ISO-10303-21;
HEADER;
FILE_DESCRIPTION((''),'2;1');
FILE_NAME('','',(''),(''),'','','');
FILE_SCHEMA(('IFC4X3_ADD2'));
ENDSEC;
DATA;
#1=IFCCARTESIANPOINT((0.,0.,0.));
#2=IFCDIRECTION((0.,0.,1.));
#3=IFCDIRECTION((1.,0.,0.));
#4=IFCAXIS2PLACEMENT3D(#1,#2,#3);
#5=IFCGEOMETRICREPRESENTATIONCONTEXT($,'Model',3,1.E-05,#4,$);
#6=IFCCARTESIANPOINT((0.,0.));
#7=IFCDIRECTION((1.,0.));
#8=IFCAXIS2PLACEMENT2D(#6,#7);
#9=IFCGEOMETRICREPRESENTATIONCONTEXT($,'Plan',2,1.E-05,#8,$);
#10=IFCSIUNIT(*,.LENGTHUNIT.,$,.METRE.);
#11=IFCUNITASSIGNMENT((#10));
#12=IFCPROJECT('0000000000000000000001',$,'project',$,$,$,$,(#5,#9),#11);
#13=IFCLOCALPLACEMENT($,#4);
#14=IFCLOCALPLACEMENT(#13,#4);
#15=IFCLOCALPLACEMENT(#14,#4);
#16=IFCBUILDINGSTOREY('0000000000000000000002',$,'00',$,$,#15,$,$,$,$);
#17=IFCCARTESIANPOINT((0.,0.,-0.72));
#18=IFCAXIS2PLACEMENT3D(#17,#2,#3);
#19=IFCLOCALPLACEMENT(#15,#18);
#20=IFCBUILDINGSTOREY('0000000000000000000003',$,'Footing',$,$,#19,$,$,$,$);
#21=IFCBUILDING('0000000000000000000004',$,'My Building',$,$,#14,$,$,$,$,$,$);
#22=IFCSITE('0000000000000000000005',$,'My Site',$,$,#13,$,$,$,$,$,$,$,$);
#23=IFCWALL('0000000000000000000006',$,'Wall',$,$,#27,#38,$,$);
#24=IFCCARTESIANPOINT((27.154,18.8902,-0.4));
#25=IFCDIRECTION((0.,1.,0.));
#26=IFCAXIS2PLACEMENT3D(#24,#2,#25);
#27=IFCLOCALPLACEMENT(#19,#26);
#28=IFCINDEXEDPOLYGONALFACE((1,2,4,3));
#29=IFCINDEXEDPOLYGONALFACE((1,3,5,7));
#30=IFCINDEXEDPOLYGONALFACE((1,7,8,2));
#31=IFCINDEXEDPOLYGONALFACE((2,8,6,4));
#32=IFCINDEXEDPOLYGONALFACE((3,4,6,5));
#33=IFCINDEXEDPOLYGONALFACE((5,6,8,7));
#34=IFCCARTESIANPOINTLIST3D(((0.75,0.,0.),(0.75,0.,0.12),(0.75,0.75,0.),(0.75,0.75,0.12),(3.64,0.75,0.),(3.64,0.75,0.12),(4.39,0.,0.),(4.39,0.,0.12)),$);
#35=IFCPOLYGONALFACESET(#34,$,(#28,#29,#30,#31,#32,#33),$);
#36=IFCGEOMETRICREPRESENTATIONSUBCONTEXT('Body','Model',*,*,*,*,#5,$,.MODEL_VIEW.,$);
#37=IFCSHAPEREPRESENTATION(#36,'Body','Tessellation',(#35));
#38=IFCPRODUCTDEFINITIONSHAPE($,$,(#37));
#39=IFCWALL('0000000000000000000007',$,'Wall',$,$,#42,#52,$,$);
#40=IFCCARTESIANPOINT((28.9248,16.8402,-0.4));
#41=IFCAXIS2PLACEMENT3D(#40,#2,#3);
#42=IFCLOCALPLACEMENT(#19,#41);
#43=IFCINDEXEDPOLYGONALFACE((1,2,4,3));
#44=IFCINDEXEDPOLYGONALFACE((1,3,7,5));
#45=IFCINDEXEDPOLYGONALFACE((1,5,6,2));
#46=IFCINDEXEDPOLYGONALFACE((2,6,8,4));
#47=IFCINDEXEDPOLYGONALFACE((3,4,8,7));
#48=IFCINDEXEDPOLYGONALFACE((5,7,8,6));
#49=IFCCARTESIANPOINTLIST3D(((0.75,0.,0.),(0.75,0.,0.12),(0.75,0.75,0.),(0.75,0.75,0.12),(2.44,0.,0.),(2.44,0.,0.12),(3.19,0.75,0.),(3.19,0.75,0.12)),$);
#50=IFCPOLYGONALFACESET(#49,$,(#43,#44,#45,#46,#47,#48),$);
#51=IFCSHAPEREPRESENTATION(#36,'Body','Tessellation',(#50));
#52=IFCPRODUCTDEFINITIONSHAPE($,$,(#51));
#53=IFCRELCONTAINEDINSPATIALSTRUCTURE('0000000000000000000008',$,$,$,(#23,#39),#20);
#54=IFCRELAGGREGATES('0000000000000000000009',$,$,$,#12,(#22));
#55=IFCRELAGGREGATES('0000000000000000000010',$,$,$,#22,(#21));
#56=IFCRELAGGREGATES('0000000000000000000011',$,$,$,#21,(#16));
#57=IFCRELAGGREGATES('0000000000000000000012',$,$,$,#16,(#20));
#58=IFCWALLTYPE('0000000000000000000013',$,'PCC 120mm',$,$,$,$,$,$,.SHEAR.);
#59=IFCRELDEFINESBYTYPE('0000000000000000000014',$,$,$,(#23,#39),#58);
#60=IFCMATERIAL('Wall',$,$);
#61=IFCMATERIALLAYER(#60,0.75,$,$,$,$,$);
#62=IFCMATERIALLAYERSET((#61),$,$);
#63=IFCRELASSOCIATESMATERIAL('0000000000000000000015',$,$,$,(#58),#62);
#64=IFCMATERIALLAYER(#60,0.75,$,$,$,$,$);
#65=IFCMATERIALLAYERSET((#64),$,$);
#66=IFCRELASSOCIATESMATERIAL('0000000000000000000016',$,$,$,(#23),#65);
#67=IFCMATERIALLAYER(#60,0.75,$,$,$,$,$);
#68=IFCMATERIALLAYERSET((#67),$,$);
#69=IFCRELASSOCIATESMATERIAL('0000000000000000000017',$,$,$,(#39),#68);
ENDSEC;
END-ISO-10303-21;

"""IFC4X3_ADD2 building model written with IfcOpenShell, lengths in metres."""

from ifc_helpers import new_model, si_unit, frame, origin_with_axes, origin_2d_with_axis, place, context, subcontext, project, spatial, line, indexed_curve, outline, extrude, material, layer, layer_set, layer_usage, type_object, element, save


model = new_model("IFC4X3_ADD2")

# Units and contexts
model_context = context("Model", 3, precision=1e-05, world=origin_with_axes())
plan_context = context("Plan", 2, precision=1e-05, world=origin_2d_with_axis())
body_context = subcontext(model_context, "Body", "Model", "MODEL_VIEW")
ifc_project = project(units=[si_unit("LENGTHUNIT", "METRE")], contexts=[model_context, plan_context])

# Site, building, storeys
site_placement = place(None, origin_with_axes())
site = spatial("IfcSite", under=ifc_project, at=site_placement, Name="My Site")
building_placement = place(site_placement, origin_with_axes())
building = spatial("IfcBuilding", under=site, at=building_placement, Name="My Building")
storey_1_placement = place(building_placement, origin_with_axes())
storey_1 = spatial("IfcBuildingStorey", under=building, at=storey_1_placement, Name="00")
storey_2_placement = place(storey_1_placement, frame((0.0, 0.0, -0.72), z_axis=(0.0, 0.0, 1.0), x_axis=(1.0, 0.0, 0.0)))
storey_2 = spatial("IfcBuildingStorey", under=storey_1, at=storey_2_placement, Name="Footing")

# Shared definitions
ifc_material_1 = material(Name="Wall")

# Walls
ifc_layer_1 = layer(ifc_material_1, 0.75)
ifc_layer_set_1 = layer_set([ifc_layer_1])
ifc_layer_usage_1 = layer_usage(ifc_layer_set_1, "AXIS2", "POSITIVE", 0.0)
ifc_layer_2 = layer(ifc_material_1, 0.75)
ifc_layer_set_2 = layer_set([ifc_layer_2])
wall_type_1 = type_object("IfcWallType", Name="PCC 120mm", PredefinedType="SHEAR", material=ifc_layer_set_2)
wall_1_placement = place(storey_2_placement, frame((27.154, 18.8902, -0.4), z_axis=(0.0, 0.0, 1.0), x_axis=(0.0, 1.0, 0.0)))
element("IfcWall", 1, at=wall_1_placement, inside=storey_2, type_object=wall_type_1, material=ifc_layer_usage_1, Name="Wall", context=body_context, shape_type="SweptSolid", body=[
    extrude(outline(indexed_curve([(0.75, 0.0), (0.75, 0.75), (3.64, 0.75), (4.39, 0.0)], segments=[line(1, 2, 3, 4, 1)])), origin_with_axes(), (0.0, 0.0, 1.0), 0.12),
])
ifc_layer_3 = layer(ifc_material_1, 0.75)
ifc_layer_set_3 = layer_set([ifc_layer_3])
ifc_layer_usage_2 = layer_usage(ifc_layer_set_3, "AXIS2", "POSITIVE", 0.0)
wall_2_placement = place(storey_2_placement, frame((28.9248, 16.8402, -0.4), z_axis=(0.0, 0.0, 1.0), x_axis=(1.0, 0.0, 0.0)))
element("IfcWall", 2, at=wall_2_placement, inside=storey_2, type_object=wall_type_1, material=ifc_layer_usage_2, Name="Wall", context=body_context, shape_type="SweptSolid", body=[
    extrude(outline(indexed_curve([(0.75, 0.0), (0.75, 0.75), (3.19, 0.75), (2.44, 0.0)], segments=[line(1, 2, 3, 4, 1)])), origin_with_axes(), (0.0, 0.0, 1.0), 0.12),
])

save(model, "model.ifc")
